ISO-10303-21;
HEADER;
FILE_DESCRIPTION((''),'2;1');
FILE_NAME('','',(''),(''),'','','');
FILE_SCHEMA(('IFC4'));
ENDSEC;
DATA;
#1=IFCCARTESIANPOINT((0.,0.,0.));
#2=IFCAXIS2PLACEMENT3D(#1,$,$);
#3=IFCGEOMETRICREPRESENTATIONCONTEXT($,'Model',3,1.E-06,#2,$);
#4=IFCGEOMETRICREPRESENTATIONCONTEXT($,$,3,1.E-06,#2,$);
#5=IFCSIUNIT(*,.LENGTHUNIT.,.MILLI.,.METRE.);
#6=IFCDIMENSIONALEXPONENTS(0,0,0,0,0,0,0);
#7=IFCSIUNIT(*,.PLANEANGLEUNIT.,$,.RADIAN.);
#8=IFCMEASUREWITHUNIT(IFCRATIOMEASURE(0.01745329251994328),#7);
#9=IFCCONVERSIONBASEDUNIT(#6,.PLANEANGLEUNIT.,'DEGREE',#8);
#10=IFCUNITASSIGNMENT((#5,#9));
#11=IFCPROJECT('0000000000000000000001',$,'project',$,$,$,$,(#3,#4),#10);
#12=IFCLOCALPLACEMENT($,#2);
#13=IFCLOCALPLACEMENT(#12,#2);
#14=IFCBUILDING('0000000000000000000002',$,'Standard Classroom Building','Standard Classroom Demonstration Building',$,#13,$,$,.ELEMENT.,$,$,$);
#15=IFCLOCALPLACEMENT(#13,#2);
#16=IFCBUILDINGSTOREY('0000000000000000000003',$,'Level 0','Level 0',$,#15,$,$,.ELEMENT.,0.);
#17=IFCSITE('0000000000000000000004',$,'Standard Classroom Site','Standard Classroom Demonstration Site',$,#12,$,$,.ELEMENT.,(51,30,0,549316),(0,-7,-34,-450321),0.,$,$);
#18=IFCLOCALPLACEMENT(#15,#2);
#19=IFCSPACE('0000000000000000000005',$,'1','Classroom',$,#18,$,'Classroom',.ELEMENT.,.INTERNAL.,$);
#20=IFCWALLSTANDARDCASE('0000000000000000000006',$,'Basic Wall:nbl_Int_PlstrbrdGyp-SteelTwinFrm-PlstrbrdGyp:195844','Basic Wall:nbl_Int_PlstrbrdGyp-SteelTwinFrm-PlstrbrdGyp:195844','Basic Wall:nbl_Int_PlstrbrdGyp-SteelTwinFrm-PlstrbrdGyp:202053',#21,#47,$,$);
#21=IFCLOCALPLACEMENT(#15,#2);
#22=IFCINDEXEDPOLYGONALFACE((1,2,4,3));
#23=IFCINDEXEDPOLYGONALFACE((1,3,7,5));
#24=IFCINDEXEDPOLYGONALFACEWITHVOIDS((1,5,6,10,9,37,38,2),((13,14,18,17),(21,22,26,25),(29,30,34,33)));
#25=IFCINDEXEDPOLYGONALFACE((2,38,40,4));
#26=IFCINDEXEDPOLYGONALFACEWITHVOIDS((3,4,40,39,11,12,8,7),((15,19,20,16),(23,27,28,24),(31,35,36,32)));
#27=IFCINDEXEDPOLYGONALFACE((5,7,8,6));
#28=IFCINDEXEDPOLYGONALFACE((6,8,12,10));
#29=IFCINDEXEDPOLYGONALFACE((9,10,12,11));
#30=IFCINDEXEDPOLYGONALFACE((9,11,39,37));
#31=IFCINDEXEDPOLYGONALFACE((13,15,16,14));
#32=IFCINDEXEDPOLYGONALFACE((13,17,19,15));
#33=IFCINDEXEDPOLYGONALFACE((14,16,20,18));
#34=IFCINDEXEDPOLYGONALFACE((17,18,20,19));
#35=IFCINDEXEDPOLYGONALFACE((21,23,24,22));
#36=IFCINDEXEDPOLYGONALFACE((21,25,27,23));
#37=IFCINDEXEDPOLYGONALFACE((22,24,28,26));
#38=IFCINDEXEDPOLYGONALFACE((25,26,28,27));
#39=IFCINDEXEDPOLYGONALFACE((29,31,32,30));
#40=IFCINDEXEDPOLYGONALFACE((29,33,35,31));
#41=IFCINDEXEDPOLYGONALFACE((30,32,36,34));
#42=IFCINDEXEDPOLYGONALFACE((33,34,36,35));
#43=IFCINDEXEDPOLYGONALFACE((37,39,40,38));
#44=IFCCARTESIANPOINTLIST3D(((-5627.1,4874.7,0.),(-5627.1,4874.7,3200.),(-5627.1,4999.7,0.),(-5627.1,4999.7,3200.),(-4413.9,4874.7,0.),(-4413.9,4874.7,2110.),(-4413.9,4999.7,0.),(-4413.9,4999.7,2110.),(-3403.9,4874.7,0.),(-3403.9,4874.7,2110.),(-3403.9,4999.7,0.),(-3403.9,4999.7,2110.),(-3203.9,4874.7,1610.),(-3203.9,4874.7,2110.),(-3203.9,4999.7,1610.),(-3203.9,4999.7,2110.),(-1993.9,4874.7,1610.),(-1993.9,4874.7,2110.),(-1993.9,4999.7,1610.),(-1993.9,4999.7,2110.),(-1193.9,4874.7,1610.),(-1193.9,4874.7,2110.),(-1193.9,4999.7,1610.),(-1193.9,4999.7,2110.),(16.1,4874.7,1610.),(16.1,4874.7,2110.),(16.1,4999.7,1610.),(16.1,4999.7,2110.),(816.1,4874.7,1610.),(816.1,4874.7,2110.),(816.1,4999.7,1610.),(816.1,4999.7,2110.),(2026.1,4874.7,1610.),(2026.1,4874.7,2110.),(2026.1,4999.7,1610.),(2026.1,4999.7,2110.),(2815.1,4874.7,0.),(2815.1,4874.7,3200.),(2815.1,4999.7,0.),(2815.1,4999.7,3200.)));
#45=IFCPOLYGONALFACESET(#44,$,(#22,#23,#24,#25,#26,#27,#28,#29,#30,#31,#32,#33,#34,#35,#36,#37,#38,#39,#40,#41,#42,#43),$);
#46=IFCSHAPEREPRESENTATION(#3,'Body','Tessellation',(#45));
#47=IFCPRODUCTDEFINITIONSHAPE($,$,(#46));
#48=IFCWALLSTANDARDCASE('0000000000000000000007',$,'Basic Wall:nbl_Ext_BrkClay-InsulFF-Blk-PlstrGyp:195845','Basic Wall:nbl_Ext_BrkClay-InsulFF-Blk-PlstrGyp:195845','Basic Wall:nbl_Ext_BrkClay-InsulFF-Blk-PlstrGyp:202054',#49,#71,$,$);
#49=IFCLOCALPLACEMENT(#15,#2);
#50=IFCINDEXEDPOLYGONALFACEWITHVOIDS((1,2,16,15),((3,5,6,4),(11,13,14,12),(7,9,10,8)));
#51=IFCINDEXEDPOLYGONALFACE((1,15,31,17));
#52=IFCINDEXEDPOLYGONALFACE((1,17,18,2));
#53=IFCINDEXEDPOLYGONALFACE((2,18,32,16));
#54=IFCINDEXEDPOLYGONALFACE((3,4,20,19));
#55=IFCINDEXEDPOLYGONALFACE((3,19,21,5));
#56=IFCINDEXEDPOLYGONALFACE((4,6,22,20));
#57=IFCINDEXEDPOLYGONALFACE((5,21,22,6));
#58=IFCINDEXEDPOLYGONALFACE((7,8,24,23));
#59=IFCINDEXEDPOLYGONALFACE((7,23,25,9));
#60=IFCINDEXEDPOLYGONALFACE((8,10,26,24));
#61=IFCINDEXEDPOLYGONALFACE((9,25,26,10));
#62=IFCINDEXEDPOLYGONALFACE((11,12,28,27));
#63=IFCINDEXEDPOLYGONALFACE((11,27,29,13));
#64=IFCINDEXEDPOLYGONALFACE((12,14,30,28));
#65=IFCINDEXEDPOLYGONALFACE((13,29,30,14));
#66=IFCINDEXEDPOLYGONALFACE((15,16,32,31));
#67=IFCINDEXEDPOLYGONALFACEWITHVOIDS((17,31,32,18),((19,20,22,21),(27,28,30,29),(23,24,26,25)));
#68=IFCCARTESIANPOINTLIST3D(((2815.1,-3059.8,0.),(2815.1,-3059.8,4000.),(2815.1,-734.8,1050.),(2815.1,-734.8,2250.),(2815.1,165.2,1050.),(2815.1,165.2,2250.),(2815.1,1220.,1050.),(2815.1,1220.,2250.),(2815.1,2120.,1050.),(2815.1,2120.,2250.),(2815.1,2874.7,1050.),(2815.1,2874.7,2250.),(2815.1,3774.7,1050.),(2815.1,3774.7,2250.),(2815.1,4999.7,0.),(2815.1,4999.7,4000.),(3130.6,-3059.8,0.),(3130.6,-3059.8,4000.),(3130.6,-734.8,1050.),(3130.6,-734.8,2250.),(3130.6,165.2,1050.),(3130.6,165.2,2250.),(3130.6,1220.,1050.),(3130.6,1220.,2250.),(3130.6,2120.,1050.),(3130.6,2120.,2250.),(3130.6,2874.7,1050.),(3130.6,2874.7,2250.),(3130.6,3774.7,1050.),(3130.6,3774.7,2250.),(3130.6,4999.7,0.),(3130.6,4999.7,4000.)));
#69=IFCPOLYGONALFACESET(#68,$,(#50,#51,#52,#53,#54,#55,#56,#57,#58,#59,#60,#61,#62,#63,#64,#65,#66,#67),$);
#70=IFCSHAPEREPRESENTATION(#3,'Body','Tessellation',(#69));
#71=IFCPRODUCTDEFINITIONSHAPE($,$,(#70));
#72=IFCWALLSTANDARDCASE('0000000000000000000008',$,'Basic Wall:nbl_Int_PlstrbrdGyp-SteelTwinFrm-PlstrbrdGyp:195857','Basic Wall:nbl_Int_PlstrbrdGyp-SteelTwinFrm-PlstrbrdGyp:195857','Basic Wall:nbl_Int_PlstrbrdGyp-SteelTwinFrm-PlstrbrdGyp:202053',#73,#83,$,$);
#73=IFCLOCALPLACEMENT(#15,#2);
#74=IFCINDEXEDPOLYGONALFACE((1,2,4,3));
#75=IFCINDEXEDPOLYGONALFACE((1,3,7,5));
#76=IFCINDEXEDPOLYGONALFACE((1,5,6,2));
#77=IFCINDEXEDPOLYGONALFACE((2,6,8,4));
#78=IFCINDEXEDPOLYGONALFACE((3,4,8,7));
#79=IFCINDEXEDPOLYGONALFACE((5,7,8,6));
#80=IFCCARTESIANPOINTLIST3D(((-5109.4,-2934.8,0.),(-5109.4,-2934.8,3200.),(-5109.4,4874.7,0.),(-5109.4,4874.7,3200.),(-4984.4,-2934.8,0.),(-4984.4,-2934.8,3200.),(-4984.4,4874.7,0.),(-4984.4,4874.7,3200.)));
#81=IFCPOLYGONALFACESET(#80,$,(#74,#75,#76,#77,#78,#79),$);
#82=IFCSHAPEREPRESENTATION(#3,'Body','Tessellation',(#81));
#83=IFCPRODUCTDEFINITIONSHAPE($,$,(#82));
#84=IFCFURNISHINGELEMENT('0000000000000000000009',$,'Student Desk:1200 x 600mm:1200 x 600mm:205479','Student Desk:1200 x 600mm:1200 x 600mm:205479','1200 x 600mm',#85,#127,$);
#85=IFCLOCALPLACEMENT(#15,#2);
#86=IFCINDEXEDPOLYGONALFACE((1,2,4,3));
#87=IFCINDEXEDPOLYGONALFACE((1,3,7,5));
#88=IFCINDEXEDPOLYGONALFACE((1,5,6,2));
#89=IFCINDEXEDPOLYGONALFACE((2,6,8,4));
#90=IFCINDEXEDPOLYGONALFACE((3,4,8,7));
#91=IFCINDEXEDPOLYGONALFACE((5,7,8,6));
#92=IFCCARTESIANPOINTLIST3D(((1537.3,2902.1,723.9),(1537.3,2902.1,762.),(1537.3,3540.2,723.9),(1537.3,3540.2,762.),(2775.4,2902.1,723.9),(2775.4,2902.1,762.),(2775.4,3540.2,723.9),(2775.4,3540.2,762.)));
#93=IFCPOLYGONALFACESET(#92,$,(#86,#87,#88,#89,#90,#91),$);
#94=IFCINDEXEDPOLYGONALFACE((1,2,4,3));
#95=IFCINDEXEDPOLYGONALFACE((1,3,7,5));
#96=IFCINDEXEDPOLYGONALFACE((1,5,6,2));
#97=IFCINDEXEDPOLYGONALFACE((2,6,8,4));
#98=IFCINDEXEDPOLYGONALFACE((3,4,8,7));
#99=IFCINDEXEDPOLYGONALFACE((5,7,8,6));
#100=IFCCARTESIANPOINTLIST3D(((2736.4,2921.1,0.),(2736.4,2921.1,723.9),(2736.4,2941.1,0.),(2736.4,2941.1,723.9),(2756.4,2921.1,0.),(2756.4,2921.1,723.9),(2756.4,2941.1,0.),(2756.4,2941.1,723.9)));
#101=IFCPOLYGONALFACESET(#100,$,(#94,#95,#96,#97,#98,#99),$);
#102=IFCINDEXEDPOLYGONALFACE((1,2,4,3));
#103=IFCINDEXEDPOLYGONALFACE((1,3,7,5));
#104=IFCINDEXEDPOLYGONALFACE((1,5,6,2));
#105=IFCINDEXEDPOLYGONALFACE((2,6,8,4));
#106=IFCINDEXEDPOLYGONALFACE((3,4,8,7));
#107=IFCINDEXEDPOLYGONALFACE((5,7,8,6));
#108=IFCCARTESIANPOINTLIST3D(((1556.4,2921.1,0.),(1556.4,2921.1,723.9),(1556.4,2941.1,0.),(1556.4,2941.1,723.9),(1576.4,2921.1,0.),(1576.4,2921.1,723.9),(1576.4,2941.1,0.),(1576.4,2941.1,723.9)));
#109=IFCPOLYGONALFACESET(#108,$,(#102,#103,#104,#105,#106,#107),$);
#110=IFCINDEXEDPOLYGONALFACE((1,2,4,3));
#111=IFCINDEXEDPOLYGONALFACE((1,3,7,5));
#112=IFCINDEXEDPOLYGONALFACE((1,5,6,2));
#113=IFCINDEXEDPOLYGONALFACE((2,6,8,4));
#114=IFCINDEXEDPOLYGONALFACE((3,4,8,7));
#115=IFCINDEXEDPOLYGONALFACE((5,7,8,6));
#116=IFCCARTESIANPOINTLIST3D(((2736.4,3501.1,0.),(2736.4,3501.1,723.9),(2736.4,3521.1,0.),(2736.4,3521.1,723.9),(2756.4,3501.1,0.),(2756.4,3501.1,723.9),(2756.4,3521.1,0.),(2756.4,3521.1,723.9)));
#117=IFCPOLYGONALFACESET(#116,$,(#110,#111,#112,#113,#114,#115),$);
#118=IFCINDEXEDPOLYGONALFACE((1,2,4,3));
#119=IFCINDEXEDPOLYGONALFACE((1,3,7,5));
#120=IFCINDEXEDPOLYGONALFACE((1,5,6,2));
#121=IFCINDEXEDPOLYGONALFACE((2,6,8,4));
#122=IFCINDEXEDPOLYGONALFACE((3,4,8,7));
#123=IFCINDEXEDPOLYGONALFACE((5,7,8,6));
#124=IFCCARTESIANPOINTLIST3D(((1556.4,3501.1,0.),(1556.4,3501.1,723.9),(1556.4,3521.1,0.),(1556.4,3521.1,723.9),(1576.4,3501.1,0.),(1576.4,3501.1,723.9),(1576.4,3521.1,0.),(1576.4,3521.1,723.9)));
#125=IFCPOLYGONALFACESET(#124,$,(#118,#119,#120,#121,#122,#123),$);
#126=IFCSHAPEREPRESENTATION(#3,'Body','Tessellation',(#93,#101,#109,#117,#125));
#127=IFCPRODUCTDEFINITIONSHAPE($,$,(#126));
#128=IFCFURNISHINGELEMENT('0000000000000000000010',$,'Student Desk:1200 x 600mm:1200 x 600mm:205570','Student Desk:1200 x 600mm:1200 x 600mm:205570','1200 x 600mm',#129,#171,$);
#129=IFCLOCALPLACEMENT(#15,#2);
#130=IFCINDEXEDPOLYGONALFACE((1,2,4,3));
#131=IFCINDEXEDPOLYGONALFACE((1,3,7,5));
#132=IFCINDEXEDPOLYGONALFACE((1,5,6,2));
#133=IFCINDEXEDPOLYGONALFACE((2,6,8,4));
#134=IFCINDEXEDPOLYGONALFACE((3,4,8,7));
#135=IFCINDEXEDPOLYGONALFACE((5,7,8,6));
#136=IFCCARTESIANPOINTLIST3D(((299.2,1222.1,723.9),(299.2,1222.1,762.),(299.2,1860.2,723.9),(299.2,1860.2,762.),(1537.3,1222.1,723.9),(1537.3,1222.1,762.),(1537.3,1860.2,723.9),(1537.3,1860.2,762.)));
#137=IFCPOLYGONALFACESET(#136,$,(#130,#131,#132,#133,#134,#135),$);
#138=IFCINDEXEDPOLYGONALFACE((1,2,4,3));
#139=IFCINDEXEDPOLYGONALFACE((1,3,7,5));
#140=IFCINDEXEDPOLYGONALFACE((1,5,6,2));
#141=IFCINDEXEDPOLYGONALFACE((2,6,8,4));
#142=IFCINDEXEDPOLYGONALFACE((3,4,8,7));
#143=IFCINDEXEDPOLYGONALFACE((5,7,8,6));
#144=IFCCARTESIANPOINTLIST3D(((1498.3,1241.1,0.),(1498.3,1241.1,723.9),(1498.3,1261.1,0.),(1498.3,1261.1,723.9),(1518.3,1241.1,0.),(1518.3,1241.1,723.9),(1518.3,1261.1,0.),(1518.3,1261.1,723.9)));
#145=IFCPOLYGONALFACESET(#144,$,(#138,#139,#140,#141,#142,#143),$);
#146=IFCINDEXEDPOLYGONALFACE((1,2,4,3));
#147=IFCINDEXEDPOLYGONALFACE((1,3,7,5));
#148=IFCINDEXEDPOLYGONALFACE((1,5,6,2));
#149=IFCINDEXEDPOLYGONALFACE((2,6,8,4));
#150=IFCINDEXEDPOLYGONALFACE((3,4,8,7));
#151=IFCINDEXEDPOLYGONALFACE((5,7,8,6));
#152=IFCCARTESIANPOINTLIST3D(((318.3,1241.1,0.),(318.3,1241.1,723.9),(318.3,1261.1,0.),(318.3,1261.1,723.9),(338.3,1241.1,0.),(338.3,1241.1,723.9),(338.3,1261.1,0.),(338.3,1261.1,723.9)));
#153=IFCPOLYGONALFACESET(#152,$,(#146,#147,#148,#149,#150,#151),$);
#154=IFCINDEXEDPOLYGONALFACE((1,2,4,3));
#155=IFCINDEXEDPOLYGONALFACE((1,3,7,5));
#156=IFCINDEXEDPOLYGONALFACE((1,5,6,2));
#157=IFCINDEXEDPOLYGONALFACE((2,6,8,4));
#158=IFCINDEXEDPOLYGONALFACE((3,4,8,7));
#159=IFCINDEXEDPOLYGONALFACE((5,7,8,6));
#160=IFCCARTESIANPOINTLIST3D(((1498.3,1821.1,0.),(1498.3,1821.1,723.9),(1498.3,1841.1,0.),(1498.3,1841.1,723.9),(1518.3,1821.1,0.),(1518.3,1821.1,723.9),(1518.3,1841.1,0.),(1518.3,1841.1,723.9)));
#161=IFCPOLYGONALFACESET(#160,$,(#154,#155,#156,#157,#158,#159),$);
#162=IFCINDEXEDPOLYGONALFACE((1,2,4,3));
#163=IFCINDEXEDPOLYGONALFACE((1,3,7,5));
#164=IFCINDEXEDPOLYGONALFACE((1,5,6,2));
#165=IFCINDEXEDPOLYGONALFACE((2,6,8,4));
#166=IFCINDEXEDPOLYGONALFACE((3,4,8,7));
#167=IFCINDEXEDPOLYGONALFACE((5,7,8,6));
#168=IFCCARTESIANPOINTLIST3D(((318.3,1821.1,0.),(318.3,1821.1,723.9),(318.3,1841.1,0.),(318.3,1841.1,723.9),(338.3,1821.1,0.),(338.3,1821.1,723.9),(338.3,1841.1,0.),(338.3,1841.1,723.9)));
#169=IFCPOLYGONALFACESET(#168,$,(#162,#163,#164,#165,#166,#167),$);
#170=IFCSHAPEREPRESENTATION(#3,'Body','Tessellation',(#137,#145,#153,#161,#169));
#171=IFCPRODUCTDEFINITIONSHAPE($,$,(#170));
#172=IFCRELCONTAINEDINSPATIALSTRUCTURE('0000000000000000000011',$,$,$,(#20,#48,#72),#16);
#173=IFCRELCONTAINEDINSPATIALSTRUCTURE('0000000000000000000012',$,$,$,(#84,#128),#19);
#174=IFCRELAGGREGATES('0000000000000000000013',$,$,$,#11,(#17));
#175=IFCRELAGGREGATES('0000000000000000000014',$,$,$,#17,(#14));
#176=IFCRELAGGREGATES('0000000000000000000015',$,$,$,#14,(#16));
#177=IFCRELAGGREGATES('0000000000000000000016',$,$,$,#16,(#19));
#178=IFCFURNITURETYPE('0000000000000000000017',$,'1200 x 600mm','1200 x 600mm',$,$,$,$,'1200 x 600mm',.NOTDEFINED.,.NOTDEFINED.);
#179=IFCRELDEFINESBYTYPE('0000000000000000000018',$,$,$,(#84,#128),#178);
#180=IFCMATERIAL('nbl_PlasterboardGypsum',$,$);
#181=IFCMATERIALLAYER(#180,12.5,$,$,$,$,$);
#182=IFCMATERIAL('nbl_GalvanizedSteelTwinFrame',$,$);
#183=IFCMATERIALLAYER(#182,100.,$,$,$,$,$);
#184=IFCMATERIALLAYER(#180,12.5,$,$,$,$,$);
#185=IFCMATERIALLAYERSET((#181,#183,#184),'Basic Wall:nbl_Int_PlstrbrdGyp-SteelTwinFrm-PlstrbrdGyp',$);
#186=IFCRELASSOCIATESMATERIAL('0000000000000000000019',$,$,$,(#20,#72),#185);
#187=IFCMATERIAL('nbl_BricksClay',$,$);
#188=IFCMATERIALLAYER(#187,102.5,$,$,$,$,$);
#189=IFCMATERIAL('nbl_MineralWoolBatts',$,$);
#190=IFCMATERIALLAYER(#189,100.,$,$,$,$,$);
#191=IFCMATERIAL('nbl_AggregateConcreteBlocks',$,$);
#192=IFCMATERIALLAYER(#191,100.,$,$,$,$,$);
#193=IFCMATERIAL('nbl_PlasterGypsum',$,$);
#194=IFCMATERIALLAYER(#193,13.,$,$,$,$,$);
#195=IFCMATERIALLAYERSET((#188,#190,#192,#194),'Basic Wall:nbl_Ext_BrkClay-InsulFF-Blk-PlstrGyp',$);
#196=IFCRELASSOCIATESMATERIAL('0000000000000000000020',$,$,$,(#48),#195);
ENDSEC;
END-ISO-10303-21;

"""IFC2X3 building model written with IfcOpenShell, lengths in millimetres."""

from ifc_helpers import new_model, entity, si_unit, converted_unit, frame, frame_2d, origin, origin_2d_with_axis, place, context, project, spatial, rectangle, extrude, source, transform, mapped, material, layer, layer_set, layer_usage, type_object, type_shapes, element, save


model = new_model("IFC2X3")

# Units and contexts
model_context = context("Model", 3, precision=1e-06, world=origin())
context_of_model = context(None, 3, precision=1e-06, world=origin())
ifc_project = project(units=[si_unit("LENGTHUNIT", "METRE", prefix="MILLI"), converted_unit("PLANEANGLEUNIT", "DEGREE", entity("IfcRatioMeasure", 0.01745329251994328), si_unit("PLANEANGLEUNIT", "RADIAN"), dimensions=[0, 0, 0, 0, 0, 0, 0])], contexts=[model_context, context_of_model])

# Site, building, storey
site_placement = place(None, origin())
site = spatial("IfcSite", under=ifc_project, at=site_placement, Name="Standard Classroom Site", Description="Standard Classroom Demonstration Site", CompositionType="ELEMENT", RefLatitude=(51, 30, 0, 549316), RefLongitude=(0, -7, -34, -450321), RefElevation=0.0)
building_placement = place(site_placement, origin())
building = spatial("IfcBuilding", under=site, at=building_placement, Name="Standard Classroom Building", Description="Standard Classroom Demonstration Building", CompositionType="ELEMENT")
storey_placement = place(building_placement, origin())
storey = spatial("IfcBuildingStorey", under=building, at=storey_placement, Name="Level 0", Description="Level 0", CompositionType="ELEMENT", Elevation=0.0)

# Walls, openings
ifc_material_1 = material(Name="nbl_PlasterboardGypsum")
ifc_layer_1 = layer(ifc_material_1, 12.5)
ifc_material_2 = material(Name="nbl_GalvanizedSteelTwinFrame")
ifc_layer_2 = layer(ifc_material_2, 100.0)
ifc_layer_3 = layer(ifc_material_1, 12.5)
ifc_layer_set_1 = layer_set([ifc_layer_1, ifc_layer_2, ifc_layer_3], Name="Basic Wall:nbl_Int_PlstrbrdGyp-SteelTwinFrm-PlstrbrdGyp")
ifc_layer_usage_1 = layer_usage(ifc_layer_set_1, "AXIS2", "NEGATIVE", 62.5)
wall_1_placement = place(storey_placement, frame((-5627.1, 4937.2, 0.0)))
wall_1 = element("IfcWallStandardCase", 1, at=wall_1_placement, inside=storey, material=ifc_layer_usage_1, Name="Basic Wall:nbl_Int_PlstrbrdGyp-SteelTwinFrm-PlstrbrdGyp:195844", Description="Basic Wall:nbl_Int_PlstrbrdGyp-SteelTwinFrm-PlstrbrdGyp:195844", ObjectType="Basic Wall:nbl_Int_PlstrbrdGyp-SteelTwinFrm-PlstrbrdGyp:202053", context=model_context, shape_type="SweptSolid", body=[
    extrude(rectangle(XDim=8442.3, YDim=125.0, at=frame_2d((4221.1, 0.0), x_axis=(-1.0, 0.0))), origin(), (0.0, 0.0, 1.0), 3200.0),
])
opening_1_placement = place(wall_1_placement, frame((1213.3, -62.5, 0.0)))
element("IfcOpeningElement", 2, at=opening_1_placement, cuts=wall_1, ObjectType="Opening", context=model_context, shape_type="SweptSolid", body=[
    extrude(rectangle(XDim=2110.0, YDim=1010.0, at=frame_2d((1055.0, 505.0), x_axis=(1.0, 0.0))), frame((0.0, 0.0, 0.0), z_axis=(0.0, 1.0, 0.0), x_axis=(0.0, 0.0, 1.0)), (0.0, 0.0, 1.0), 125.0),
])
opening_2_placement = place(wall_1_placement, frame((7653.2, 62.5, 1610.0)))
element("IfcOpeningElement", 3, at=opening_2_placement, cuts=wall_1, ObjectType="Opening", context=model_context, shape_type="SweptSolid", body=[
    extrude(rectangle(XDim=500.0, YDim=1210.0, at=frame_2d((250.0, 605.0), x_axis=(-1.0, 0.0))), frame((0.0, 0.0, 0.0), z_axis=(0.0, -1.0, 0.0), x_axis=(0.0, 0.0, 1.0)), (0.0, 0.0, 1.0), 125.0),
])
opening_3_placement = place(wall_1_placement, frame((5643.3, 62.5, 1610.0)))
element("IfcOpeningElement", 4, at=opening_3_placement, cuts=wall_1, ObjectType="Opening", context=model_context, shape_type="SweptSolid", body=[
    extrude(rectangle(XDim=500.0, YDim=1210.0, at=frame_2d((250.0, 605.0), x_axis=(-1.0, 0.0))), frame((0.0, 0.0, 0.0), z_axis=(0.0, -1.0, 0.0), x_axis=(0.0, 0.0, 1.0)), (0.0, 0.0, 1.0), 125.0),
])
opening_4_placement = place(wall_1_placement, frame((3633.3, 62.5, 1610.0)))
element("IfcOpeningElement", 5, at=opening_4_placement, cuts=wall_1, ObjectType="Opening", context=model_context, shape_type="SweptSolid", body=[
    extrude(rectangle(XDim=500.0, YDim=1210.0, at=frame_2d((250.0, 605.0), x_axis=(-1.0, 0.0))), frame((0.0, 0.0, 0.0), z_axis=(0.0, -1.0, 0.0), x_axis=(0.0, 0.0, 1.0)), (0.0, 0.0, 1.0), 125.0),
])
ifc_material_3 = material(Name="nbl_BricksClay")
ifc_layer_4 = layer(ifc_material_3, 102.5)
ifc_material_4 = material(Name="nbl_MineralWoolBatts")
ifc_layer_5 = layer(ifc_material_4, 100.0)
ifc_material_5 = material(Name="nbl_AggregateConcreteBlocks")
ifc_layer_6 = layer(ifc_material_5, 100.0)
ifc_material_6 = material(Name="nbl_PlasterGypsum")
ifc_layer_7 = layer(ifc_material_6, 13.0)
ifc_layer_set_2 = layer_set([ifc_layer_4, ifc_layer_5, ifc_layer_6, ifc_layer_7], Name="Basic Wall:nbl_Ext_BrkClay-InsulFF-Blk-PlstrGyp")
ifc_layer_usage_2 = layer_usage(ifc_layer_set_2, "AXIS2", "NEGATIVE", 157.8)
wall_2_placement = place(storey_placement, frame((2972.9, 4999.7, 0.0), z_axis=(0.0, 0.0, 1.0), x_axis=(0.0, -1.0, 0.0)))
wall_2 = element("IfcWallStandardCase", 6, at=wall_2_placement, inside=storey, material=ifc_layer_usage_2, Name="Basic Wall:nbl_Ext_BrkClay-InsulFF-Blk-PlstrGyp:195845", Description="Basic Wall:nbl_Ext_BrkClay-InsulFF-Blk-PlstrGyp:195845", ObjectType="Basic Wall:nbl_Ext_BrkClay-InsulFF-Blk-PlstrGyp:202054", context=model_context, shape_type="SweptSolid", body=[
    extrude(rectangle(XDim=8059.5, YDim=315.5, at=frame_2d((4029.8, 0.0), x_axis=(-1.0, 0.0))), origin(), (0.0, 0.0, 1.0), 4000.0),
])
opening_5_placement = place(wall_2_placement, frame((1225.0, -157.8, 1050.0)))
element("IfcOpeningElement", 7, at=opening_5_placement, cuts=wall_2, ObjectType="Opening", context=model_context, shape_type="SweptSolid", body=[
    extrude(rectangle(XDim=1200.0, YDim=900.0, at=frame_2d((600.0, 450.0), x_axis=(-1.0, 0.0))), frame((0.0, 0.0, 0.0), z_axis=(0.0, 1.0, 0.0), x_axis=(0.0, 0.0, 1.0)), (0.0, 0.0, 1.0), 315.5),
])
opening_6_placement = place(wall_2_placement, frame((4834.5, -157.8, 1050.0)))
element("IfcOpeningElement", 8, at=opening_6_placement, cuts=wall_2, ObjectType="Opening", context=model_context, shape_type="SweptSolid", body=[
    extrude(rectangle(XDim=1200.0, YDim=900.0, at=frame_2d((600.0, 450.0), x_axis=(-1.0, 0.0))), frame((0.0, 0.0, 0.0), z_axis=(0.0, 1.0, 0.0), x_axis=(0.0, 0.0, 1.0)), (0.0, 0.0, 1.0), 315.5),
])
opening_7_placement = place(wall_2_placement, frame((2879.8, -157.8, 1050.0)))
element("IfcOpeningElement", 9, at=opening_7_placement, cuts=wall_2, ObjectType="Opening", context=model_context, shape_type="SweptSolid", body=[
    extrude(rectangle(XDim=1200.0, YDim=900.0, at=frame_2d((600.0, 450.0), x_axis=(-1.0, 0.0))), frame((0.0, 0.0, 0.0), z_axis=(0.0, 1.0, 0.0), x_axis=(0.0, 0.0, 1.0)), (0.0, 0.0, 1.0), 315.5),
])

# Wall
ifc_layer_usage_3 = layer_usage(ifc_layer_set_1, "AXIS2", "NEGATIVE", 62.5)
wall_3_placement = place(storey_placement, frame((-5046.9, 4874.7, 0.0), z_axis=(0.0, 0.0, 1.0), x_axis=(0.0, -1.0, 0.0)))
element("IfcWallStandardCase", 10, at=wall_3_placement, inside=storey, material=ifc_layer_usage_3, Name="Basic Wall:nbl_Int_PlstrbrdGyp-SteelTwinFrm-PlstrbrdGyp:195857", Description="Basic Wall:nbl_Int_PlstrbrdGyp-SteelTwinFrm-PlstrbrdGyp:195857", ObjectType="Basic Wall:nbl_Int_PlstrbrdGyp-SteelTwinFrm-PlstrbrdGyp:202053", context=model_context, shape_type="SweptSolid", body=[
    extrude(rectangle(XDim=7809.5, YDim=125.0, at=frame_2d((3904.8, 0.0), x_axis=(-1.0, 0.0))), origin(), (0.0, 0.0, 1.0), 3200.0),
])

# Shared definitions
space_placement = place(storey_placement, origin())
space = spatial("IfcSpace", under=storey, at=space_placement, Name="1", Description="Classroom", LongName="Classroom", CompositionType="ELEMENT", InteriorOrExteriorSpace="INTERNAL")

# Furnishing elements
furniture_type = type_object("IfcFurnitureType", Name="1200 x 600mm", Description="1200 x 600mm", ElementType="1200 x 600mm", AssemblyPlace="NOTDEFINED")
shared_shape_1 = source(origin(), model_context, "Body", "SweptSolid", [
    extrude(rectangle(XDim=1238.1, YDim=638.1, at=origin_2d_with_axis()), frame((600.0, 300.0, 723.9), z_axis=(0.0, 0.0, 1.0), x_axis=(-1.0, 0.0, 0.0)), (0.0, 0.0, 1.0), 38.1),
    extrude(rectangle(XDim=20.0, YDim=20.0, at=origin_2d_with_axis()), frame((1190.0, 10.0, 0.0)), (0.0, 0.0, 1.0), 723.9),
    extrude(rectangle(XDim=20.0, YDim=20.0, at=origin_2d_with_axis()), frame((10.0, 10.0, 0.0), z_axis=(0.0, 0.0, 1.0), x_axis=(0.0, 1.0, 0.0)), (0.0, 0.0, 1.0), 723.9),
    extrude(rectangle(XDim=20.0, YDim=20.0, at=origin_2d_with_axis()), frame((1190.0, 590.0, 0.0), z_axis=(0.0, 0.0, 1.0), x_axis=(0.0, -1.0, 0.0)), (0.0, 0.0, 1.0), 723.9),
    extrude(rectangle(XDim=20.0, YDim=20.0, at=origin_2d_with_axis()), frame((10.0, 590.0, 0.0), z_axis=(0.0, 0.0, 1.0), x_axis=(-1.0, 0.0, 0.0)), (0.0, 0.0, 1.0), 723.9),
])
type_shapes(furniture_type, [shared_shape_1])
for number, where, name, description in (
    (11, (1556.4, 2921.1, 0.0), "Student Desk:1200 x 600mm:1200 x 600mm:205479", "Student Desk:1200 x 600mm:1200 x 600mm:205479"),
    (12, (318.3, 1241.1, 0.0), "Student Desk:1200 x 600mm:1200 x 600mm:205570", "Student Desk:1200 x 600mm:1200 x 600mm:205570"),
):
    element("IfcFurnishingElement", number, at=place(space_placement, frame(where)), inside=space, type_object=furniture_type, Name=name, Description=description, ObjectType="1200 x 600mm", context=model_context, shape_type="MappedRepresentation", body=[
        mapped(shared_shape_1, transform((0.0, 0.0, 0.0), scale=1.0)),
    ])

save(model, "model.ifc")
